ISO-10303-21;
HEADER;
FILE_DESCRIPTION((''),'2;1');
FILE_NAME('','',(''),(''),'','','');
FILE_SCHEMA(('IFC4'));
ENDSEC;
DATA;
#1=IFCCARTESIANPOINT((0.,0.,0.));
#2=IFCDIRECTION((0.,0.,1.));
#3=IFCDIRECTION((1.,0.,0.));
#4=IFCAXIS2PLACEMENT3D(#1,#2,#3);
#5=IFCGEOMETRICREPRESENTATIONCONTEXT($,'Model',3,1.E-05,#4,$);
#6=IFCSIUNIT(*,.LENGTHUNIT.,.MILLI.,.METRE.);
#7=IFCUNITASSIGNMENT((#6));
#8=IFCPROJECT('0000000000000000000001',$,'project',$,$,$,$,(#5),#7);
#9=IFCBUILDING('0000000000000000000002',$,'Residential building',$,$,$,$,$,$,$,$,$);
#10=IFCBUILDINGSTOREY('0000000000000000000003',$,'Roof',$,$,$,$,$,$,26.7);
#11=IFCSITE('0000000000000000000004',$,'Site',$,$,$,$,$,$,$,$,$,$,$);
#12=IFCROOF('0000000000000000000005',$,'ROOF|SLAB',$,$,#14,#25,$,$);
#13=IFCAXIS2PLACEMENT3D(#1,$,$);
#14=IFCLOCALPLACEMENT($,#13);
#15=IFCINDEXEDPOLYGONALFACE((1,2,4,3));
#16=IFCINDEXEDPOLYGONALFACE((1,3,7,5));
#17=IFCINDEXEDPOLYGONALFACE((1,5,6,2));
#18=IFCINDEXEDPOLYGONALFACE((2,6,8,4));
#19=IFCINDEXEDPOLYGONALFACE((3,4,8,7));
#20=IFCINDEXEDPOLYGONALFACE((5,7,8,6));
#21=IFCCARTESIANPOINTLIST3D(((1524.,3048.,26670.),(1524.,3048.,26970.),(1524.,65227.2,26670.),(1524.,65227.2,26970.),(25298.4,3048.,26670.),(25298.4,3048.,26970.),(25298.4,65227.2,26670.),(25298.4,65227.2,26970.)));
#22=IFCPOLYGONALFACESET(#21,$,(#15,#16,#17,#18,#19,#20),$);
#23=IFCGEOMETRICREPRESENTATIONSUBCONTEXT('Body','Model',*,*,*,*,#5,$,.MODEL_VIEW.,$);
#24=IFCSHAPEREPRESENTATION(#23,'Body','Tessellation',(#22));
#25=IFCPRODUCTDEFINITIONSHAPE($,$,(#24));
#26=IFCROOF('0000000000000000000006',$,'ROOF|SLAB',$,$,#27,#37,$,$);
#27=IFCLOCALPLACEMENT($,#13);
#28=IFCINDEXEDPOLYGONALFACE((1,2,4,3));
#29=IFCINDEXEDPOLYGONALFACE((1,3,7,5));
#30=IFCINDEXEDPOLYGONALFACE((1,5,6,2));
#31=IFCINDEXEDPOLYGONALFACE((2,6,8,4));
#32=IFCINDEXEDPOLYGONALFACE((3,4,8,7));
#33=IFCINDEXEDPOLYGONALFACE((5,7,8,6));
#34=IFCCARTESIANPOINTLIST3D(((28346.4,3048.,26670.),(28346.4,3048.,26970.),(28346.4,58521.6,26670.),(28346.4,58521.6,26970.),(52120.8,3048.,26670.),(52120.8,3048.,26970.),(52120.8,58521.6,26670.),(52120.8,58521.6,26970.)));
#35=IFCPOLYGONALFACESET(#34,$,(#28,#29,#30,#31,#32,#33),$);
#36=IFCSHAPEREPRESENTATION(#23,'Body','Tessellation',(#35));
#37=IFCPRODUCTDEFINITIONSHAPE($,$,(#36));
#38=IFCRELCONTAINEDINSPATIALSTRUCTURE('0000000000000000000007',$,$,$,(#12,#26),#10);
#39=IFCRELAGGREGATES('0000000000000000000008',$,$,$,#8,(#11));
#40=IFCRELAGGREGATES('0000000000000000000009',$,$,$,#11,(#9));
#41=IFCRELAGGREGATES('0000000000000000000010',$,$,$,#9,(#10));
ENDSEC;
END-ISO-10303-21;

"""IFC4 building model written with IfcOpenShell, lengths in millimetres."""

from ifc_helpers import new_model, si_unit, frame, origin_with_axes, place, context, subcontext, project, spatial, indexed_curve, outline, extrude, element, save


model = new_model("IFC4")

# Units and contexts
model_context = context("Model", 3, precision=1e-05, world=origin_with_axes())
body_context = subcontext(model_context, "Body", "Model", "MODEL_VIEW")
ifc_project = project(units=[si_unit("LENGTHUNIT", "METRE", prefix="MILLI")], contexts=[model_context])

# Site, building, storey
site = spatial("IfcSite", under=ifc_project, Name="Site")
building = spatial("IfcBuilding", under=site, Name="Residential building")
storey = spatial("IfcBuildingStorey", under=building, Name="Roof", Elevation=26.7)

# Roofs
roof_1_placement = place(None, frame((1524.0, 3048.0, 26670.0), z_axis=(0.0, 0.0, 1.0), x_axis=(1.0, 0.0, 0.0)))
element("IfcRoof", 1, at=roof_1_placement, inside=storey, Name="ROOF|SLAB", context=body_context, shape_type="SweptSolid", body=[
    extrude(outline(indexed_curve([(0.0, 0.0), (23774.4, 0.0), (23774.4, 62179.2), (0.0, 62179.2), (0.0, 0.0)])), None, (0.0, 0.0, 1.0), 300.0),
])
roof_2_placement = place(None, frame((28346.4, 3048.0, 26670.0), z_axis=(0.0, 0.0, 1.0), x_axis=(1.0, 0.0, 0.0)))
element("IfcRoof", 2, at=roof_2_placement, inside=storey, Name="ROOF|SLAB", context=body_context, shape_type="SweptSolid", body=[
    extrude(outline(indexed_curve([(0.0, 0.0), (23774.4, 0.0), (23774.4, 55473.6), (0.0, 55473.6), (0.0, 0.0)])), None, (0.0, 0.0, 1.0), 300.0),
])

save(model, "model.ifc")
